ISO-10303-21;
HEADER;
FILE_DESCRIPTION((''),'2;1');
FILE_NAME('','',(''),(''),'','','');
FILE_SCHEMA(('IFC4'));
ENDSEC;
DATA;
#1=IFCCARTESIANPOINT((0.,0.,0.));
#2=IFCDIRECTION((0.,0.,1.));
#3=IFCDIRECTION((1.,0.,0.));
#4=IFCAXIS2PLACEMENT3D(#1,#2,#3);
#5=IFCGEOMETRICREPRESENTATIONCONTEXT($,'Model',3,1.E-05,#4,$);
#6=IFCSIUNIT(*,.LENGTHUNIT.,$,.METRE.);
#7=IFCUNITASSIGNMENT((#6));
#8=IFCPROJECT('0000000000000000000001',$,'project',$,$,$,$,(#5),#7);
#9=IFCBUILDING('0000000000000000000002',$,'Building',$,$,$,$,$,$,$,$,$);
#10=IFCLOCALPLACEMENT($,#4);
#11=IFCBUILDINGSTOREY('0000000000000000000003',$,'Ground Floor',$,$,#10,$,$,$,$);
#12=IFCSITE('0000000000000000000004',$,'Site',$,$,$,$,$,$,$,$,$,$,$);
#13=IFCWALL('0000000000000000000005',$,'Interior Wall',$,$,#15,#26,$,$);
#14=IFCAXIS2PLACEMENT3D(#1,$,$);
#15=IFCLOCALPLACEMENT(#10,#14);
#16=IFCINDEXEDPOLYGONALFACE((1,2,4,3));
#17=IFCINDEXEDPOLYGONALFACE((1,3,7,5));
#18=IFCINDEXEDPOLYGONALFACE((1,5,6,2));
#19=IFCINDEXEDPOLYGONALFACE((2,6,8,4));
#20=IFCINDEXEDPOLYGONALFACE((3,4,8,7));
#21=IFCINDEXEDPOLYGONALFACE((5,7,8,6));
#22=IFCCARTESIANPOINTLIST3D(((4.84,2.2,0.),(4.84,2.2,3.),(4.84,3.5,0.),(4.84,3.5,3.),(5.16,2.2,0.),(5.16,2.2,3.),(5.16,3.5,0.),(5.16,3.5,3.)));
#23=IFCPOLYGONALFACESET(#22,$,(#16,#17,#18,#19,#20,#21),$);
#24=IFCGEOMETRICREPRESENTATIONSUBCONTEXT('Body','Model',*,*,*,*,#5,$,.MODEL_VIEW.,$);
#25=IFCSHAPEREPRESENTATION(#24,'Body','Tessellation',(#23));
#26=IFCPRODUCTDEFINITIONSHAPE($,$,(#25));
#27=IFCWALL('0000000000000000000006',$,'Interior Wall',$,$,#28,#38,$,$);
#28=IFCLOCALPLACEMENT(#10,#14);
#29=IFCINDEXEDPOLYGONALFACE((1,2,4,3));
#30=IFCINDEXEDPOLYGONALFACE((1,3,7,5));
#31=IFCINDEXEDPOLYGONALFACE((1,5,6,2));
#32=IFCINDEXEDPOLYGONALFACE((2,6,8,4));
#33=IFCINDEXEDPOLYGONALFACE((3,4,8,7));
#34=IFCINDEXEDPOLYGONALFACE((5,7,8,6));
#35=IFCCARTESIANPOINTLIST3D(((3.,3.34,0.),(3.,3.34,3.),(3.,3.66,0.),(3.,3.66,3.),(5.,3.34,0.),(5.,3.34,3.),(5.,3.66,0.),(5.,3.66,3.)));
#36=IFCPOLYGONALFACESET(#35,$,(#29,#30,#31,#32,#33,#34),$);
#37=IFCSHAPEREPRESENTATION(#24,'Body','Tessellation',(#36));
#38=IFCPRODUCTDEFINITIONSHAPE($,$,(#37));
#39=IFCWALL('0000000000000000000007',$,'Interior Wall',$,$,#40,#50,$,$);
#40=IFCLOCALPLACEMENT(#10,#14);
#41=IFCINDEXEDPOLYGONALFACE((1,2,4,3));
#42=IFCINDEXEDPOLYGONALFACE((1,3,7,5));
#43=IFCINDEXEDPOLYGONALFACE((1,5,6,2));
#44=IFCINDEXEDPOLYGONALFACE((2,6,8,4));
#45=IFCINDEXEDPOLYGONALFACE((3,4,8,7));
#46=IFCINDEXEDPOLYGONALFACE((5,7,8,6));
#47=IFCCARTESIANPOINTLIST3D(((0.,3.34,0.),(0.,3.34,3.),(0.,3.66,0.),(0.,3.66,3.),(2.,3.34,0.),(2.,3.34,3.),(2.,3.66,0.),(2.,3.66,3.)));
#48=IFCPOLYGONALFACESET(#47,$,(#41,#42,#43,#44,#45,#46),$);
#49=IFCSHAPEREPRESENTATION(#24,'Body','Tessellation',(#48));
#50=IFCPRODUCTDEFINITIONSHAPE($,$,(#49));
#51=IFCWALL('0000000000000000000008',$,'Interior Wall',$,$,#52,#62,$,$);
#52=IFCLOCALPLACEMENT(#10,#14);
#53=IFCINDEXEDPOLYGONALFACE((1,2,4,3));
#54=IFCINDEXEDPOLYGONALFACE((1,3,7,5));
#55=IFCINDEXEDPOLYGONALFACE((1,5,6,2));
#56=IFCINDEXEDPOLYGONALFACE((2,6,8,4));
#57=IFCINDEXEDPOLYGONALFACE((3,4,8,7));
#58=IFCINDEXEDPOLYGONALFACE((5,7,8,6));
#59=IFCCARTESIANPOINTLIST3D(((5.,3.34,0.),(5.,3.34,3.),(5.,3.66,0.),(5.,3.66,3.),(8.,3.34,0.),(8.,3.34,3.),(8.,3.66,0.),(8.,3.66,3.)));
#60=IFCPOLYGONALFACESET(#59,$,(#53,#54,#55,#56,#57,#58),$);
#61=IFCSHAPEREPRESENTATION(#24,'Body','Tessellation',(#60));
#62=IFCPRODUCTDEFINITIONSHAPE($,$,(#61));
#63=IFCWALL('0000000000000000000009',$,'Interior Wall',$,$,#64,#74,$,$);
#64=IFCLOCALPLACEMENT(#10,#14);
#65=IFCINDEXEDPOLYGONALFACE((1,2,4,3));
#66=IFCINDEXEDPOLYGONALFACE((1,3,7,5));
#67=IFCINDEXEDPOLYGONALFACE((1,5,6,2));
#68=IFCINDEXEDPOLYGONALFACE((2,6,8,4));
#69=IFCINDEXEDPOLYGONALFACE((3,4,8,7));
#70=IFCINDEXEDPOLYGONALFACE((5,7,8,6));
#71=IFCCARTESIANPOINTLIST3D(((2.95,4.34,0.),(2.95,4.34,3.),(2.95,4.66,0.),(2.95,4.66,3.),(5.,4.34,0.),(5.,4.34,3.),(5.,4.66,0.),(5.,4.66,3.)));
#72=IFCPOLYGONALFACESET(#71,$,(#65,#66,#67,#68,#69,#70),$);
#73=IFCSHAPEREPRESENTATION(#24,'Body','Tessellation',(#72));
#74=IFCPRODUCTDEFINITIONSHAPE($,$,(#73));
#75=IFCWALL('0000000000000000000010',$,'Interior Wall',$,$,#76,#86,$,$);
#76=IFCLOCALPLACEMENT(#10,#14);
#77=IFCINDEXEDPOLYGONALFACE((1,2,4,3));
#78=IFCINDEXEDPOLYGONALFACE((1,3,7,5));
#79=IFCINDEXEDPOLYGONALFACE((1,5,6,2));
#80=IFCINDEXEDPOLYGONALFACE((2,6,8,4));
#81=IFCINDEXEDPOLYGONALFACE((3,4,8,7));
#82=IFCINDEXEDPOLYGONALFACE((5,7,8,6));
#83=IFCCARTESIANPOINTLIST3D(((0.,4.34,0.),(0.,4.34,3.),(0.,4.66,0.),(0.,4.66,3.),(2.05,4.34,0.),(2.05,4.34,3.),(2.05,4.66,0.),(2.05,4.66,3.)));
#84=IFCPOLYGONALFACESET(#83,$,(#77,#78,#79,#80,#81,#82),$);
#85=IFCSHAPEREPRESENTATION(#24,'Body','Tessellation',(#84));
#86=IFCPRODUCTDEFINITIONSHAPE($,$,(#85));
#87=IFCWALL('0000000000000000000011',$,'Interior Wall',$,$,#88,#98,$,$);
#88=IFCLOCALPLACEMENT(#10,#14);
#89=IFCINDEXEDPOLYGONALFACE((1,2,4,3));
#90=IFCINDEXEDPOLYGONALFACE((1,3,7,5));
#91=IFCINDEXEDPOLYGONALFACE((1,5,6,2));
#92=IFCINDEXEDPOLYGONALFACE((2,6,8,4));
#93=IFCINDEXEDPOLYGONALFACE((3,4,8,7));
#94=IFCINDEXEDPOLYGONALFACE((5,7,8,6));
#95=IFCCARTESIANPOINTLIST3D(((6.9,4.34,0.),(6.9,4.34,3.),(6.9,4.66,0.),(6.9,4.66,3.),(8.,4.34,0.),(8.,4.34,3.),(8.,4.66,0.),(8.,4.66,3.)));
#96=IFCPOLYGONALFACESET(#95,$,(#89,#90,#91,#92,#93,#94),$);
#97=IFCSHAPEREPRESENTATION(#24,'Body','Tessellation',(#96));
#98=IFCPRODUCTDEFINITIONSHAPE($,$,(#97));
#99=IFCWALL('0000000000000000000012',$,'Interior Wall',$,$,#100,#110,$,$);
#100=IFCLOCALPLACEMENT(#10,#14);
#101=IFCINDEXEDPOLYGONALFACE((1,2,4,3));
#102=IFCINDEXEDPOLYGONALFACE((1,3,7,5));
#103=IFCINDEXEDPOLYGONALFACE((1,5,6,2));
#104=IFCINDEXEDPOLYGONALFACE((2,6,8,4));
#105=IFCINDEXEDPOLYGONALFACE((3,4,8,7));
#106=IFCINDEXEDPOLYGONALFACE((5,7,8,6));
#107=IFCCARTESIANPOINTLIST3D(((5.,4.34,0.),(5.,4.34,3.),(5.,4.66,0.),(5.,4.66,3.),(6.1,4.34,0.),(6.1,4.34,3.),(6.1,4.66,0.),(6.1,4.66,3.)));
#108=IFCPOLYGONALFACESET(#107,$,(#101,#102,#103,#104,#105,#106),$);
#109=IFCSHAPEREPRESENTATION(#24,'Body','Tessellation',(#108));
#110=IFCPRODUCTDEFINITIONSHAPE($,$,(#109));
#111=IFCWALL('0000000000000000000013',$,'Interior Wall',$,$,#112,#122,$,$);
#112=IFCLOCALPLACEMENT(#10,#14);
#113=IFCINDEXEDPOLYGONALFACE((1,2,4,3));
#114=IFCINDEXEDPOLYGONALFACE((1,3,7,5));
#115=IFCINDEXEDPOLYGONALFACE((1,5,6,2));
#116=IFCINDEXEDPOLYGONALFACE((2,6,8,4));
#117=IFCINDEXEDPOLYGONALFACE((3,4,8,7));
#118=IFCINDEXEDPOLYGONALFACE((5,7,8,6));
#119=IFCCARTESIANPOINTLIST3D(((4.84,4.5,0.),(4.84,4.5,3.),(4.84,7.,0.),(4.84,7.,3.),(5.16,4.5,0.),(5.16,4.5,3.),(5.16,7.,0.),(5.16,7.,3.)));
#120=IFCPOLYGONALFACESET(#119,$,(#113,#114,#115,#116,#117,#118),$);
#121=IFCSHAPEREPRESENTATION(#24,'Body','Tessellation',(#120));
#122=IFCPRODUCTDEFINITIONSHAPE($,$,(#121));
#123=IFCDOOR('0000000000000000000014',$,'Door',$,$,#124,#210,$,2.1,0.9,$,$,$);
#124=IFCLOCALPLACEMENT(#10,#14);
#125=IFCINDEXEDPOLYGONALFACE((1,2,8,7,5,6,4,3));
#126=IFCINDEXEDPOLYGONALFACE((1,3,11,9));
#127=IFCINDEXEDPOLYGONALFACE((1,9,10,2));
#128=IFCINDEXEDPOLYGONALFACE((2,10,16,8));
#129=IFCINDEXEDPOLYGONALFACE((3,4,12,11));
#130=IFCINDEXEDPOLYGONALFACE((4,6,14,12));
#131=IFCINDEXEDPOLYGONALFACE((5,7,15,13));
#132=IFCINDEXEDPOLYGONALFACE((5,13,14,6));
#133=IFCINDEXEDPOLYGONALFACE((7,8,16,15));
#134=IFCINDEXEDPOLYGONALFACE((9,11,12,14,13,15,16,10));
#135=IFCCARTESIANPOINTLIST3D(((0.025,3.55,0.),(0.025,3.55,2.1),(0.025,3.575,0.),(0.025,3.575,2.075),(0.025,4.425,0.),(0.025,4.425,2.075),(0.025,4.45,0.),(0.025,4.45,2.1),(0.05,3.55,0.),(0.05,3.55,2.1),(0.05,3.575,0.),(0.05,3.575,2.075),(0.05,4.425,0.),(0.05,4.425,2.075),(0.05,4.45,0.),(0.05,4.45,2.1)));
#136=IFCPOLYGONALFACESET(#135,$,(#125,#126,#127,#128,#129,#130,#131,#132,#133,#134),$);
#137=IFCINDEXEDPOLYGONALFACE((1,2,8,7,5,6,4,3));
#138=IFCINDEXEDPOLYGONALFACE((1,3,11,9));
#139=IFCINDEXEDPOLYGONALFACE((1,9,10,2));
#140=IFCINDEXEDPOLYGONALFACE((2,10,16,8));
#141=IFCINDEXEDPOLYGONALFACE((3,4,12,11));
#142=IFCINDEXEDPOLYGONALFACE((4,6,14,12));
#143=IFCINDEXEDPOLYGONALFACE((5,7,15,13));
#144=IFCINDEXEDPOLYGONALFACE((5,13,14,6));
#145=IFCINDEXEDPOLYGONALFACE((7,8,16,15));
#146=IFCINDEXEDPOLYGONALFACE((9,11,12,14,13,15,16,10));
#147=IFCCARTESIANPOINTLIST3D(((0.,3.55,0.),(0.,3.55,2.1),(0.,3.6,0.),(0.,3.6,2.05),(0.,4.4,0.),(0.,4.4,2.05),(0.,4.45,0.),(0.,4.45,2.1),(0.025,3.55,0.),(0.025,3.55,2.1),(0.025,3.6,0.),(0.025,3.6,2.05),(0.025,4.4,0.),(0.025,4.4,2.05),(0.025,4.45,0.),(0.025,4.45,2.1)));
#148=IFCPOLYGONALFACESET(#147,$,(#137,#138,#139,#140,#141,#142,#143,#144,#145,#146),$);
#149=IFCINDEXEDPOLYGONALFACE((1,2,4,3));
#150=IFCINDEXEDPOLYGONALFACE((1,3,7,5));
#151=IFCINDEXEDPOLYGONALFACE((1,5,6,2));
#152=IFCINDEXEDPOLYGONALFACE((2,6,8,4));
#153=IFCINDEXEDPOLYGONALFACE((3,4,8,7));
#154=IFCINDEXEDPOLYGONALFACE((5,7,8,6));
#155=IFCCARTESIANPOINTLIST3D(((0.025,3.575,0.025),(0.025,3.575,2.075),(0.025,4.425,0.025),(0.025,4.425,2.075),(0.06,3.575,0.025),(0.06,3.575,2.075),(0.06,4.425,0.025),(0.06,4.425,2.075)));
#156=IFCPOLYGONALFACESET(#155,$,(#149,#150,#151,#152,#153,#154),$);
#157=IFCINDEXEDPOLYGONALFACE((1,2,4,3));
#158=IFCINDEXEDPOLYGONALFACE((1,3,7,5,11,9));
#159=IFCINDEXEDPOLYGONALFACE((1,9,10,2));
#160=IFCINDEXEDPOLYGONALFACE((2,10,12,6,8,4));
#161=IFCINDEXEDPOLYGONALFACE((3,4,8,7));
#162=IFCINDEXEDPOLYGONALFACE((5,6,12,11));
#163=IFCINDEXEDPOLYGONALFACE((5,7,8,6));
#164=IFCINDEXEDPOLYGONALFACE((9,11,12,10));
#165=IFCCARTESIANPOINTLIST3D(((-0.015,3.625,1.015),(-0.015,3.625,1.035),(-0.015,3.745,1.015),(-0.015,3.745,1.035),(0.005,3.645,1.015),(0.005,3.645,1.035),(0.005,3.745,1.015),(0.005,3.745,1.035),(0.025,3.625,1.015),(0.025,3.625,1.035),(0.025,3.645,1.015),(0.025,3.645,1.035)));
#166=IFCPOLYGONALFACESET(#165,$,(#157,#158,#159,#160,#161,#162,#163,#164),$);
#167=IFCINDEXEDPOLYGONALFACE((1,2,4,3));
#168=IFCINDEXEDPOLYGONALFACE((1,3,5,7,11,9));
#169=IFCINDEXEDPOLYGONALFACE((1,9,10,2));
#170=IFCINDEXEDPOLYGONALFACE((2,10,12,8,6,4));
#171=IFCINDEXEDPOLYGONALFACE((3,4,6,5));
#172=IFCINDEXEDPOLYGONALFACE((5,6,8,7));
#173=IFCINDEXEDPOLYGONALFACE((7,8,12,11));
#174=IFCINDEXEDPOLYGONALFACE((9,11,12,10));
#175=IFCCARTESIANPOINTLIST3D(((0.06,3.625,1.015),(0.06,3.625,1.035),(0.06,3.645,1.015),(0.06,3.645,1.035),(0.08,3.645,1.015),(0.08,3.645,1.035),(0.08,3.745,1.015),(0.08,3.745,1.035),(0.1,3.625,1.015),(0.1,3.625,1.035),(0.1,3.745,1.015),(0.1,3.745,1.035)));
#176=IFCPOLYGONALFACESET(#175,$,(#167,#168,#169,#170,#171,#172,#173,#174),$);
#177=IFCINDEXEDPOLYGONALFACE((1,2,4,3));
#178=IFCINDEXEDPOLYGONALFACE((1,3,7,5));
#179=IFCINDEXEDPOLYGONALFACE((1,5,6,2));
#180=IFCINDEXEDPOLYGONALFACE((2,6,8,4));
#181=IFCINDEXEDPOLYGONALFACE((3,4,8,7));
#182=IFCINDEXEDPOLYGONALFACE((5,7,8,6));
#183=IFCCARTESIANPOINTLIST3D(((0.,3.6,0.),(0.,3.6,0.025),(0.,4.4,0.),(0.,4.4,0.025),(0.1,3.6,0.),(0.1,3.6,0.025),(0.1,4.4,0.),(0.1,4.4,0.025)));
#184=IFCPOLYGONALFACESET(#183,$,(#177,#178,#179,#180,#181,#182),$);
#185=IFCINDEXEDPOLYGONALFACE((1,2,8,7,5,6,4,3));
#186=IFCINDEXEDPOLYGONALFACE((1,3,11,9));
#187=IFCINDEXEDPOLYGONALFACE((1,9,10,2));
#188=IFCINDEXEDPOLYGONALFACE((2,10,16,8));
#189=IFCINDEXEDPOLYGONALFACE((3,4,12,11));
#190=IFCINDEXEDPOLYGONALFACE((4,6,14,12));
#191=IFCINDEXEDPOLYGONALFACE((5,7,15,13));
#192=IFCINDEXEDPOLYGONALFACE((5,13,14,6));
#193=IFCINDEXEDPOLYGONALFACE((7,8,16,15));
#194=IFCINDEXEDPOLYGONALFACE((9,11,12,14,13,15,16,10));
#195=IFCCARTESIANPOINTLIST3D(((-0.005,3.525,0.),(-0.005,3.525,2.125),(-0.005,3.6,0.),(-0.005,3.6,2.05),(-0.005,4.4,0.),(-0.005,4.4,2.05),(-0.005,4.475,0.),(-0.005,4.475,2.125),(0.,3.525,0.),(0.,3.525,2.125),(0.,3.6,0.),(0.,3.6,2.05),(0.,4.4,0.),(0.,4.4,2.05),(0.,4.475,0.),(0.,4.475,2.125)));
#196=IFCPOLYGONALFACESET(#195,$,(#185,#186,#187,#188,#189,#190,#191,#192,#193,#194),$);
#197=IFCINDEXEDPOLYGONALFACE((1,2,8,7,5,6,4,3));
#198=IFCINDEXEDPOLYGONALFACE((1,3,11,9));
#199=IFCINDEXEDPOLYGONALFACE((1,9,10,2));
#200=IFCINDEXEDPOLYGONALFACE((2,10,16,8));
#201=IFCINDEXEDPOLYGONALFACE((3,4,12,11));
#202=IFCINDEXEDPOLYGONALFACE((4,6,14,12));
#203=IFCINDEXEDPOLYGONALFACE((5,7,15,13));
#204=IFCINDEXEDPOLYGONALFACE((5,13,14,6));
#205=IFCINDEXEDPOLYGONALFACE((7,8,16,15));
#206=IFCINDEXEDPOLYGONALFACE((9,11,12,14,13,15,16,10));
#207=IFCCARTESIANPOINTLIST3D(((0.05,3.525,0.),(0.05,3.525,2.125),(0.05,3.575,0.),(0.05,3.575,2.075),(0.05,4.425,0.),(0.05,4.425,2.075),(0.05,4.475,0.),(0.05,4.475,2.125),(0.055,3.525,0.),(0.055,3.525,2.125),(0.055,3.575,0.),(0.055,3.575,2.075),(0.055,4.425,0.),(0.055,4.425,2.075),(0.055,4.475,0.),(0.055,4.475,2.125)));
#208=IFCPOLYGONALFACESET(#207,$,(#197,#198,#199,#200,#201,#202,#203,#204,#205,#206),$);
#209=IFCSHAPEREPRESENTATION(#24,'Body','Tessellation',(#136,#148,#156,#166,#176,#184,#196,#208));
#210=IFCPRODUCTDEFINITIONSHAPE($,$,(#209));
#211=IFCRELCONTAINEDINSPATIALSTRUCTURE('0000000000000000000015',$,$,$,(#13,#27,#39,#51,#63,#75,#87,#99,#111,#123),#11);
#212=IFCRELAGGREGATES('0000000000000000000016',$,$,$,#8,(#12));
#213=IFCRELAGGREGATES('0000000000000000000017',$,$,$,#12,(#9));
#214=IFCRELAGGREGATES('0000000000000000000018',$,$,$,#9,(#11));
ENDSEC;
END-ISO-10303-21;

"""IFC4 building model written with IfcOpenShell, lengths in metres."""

from ifc_helpers import new_model, si_unit, frame, origin_with_axes, place, context, subcontext, project, spatial, line, indexed_curve, outline, extrude, element, save


model = new_model("IFC4")

# Units and contexts
model_context = context("Model", 3, precision=1e-05, world=origin_with_axes())
body_context = subcontext(model_context, "Body", "Model", "MODEL_VIEW")
ifc_project = project(units=[si_unit("LENGTHUNIT", "METRE")], contexts=[model_context])

# Site, building, storey
site = spatial("IfcSite", under=ifc_project, Name="Site")
building = spatial("IfcBuilding", under=site, Name="Building")
storey_placement = place(None, origin_with_axes())
storey = spatial("IfcBuildingStorey", under=building, at=storey_placement, Name="Ground Floor")

# Walls
wall_1_placement = place(storey_placement, frame((5.0, 2.2, 0.0), z_axis=(0.0, 0.0, 1.0), x_axis=(0.0, 1.0, 0.0)))
element("IfcWall", 1, at=wall_1_placement, inside=storey, Name="Interior Wall", context=body_context, shape_type="SweptSolid", body=[
    extrude(outline(indexed_curve([(0.0, 0.0), (0.0, 0.32), (1.3, 0.32), (1.3, 0.0), (0.0, 0.0)], self_intersect=False)), frame((0.0, -0.16, 0.0), z_axis=(0.0, 0.0, 1.0), x_axis=(1.0, 0.0, 0.0)), (0.0, 0.0, 1.0), 3.0),
])
for number, where, z_axis, x_axis, name in (
    (2, (5.0, 3.5, 0.0), (0.0, 0.0, 1.0), (-1.0, 0.0, 0.0), "Interior Wall"),
    (3, (2.0, 3.5, 0.0), (0.0, 0.0, 1.0), (-1.0, 0.0, 0.0), "Interior Wall"),
):
    element("IfcWall", number, at=place(storey_placement, frame(where, z_axis=z_axis, x_axis=x_axis)), inside=storey, Name=name, context=body_context, shape_type="SweptSolid", body=[
        extrude(outline(indexed_curve([(0.0, 0.0), (0.0, 0.32), (2.0, 0.32), (2.0, 0.0), (0.0, 0.0)], self_intersect=False)), frame((0.0, -0.16, 0.0), z_axis=(0.0, 0.0, 1.0), x_axis=(1.0, 0.0, 0.0)), (0.0, 0.0, 1.0), 3.0),
    ])
wall_2_placement = place(storey_placement, frame((8.0, 3.5, 0.0), z_axis=(0.0, 0.0, 1.0), x_axis=(-1.0, 0.0, 0.0)))
element("IfcWall", 4, at=wall_2_placement, inside=storey, Name="Interior Wall", context=body_context, shape_type="SweptSolid", body=[
    extrude(outline(indexed_curve([(0.0, 0.0), (0.0, 0.32), (3.0, 0.32), (3.0, 0.0), (0.0, 0.0)], self_intersect=False)), frame((0.0, -0.16, 0.0), z_axis=(0.0, 0.0, 1.0), x_axis=(1.0, 0.0, 0.0)), (0.0, 0.0, 1.0), 3.0),
])
for number, where, z_axis, x_axis, name in (
    (5, (5.0, 4.5, 0.0), (0.0, 0.0, 1.0), (-1.0, 0.0, 0.0), "Interior Wall"),
    (6, (2.05, 4.5, 0.0), (0.0, 0.0, 1.0), (-1.0, 0.0, 0.0), "Interior Wall"),
):
    element("IfcWall", number, at=place(storey_placement, frame(where, z_axis=z_axis, x_axis=x_axis)), inside=storey, Name=name, context=body_context, shape_type="SweptSolid", body=[
        extrude(outline(indexed_curve([(0.0, 0.0), (0.0, 0.32), (2.05, 0.32), (2.05, 0.0), (0.0, 0.0)], self_intersect=False)), frame((0.0, -0.16, 0.0), z_axis=(0.0, 0.0, 1.0), x_axis=(1.0, 0.0, 0.0)), (0.0, 0.0, 1.0), 3.0),
    ])
for number, where, z_axis, x_axis, name in (
    (7, (8.0, 4.5, 0.0), (0.0, 0.0, 1.0), (-1.0, 0.0, 0.0), "Interior Wall"),
    (8, (6.1, 4.5, 0.0), (0.0, 0.0, 1.0), (-1.0, 0.0, 0.0), "Interior Wall"),
):
    element("IfcWall", number, at=place(storey_placement, frame(where, z_axis=z_axis, x_axis=x_axis)), inside=storey, Name=name, context=body_context, shape_type="SweptSolid", body=[
        extrude(outline(indexed_curve([(0.0, 0.0), (0.0, 0.32), (1.1, 0.32), (1.1, 0.0), (0.0, 0.0)], self_intersect=False)), frame((0.0, -0.16, 0.0), z_axis=(0.0, 0.0, 1.0), x_axis=(1.0, 0.0, 0.0)), (0.0, 0.0, 1.0), 3.0),
    ])
wall_3_placement = place(storey_placement, frame((5.0, 4.5, 0.0), z_axis=(0.0, 0.0, 1.0), x_axis=(0.0, 1.0, 0.0)))
element("IfcWall", 9, at=wall_3_placement, inside=storey, Name="Interior Wall", context=body_context, shape_type="SweptSolid", body=[
    extrude(outline(indexed_curve([(0.0, 0.0), (0.0, 0.32), (2.5, 0.32), (2.5, 0.0), (0.0, 0.0)], self_intersect=False)), frame((0.0, -0.16, 0.0), z_axis=(0.0, 0.0, 1.0), x_axis=(1.0, 0.0, 0.0)), (0.0, 0.0, 1.0), 3.0),
])

# Door
door_1_placement = place(storey_placement, frame((0.0, 4.45, 0.0), z_axis=(0.0, 0.0, 1.0), x_axis=(0.0, -1.0, 0.0)))
element("IfcDoor", 10, at=door_1_placement, inside=storey, Name="Door", OverallHeight=2.1, OverallWidth=0.9, context=body_context, shape_type="SweptSolid", body=[
    extrude(outline(indexed_curve([(0.0, 0.0), (0.0, 2.1), (0.9, 2.1), (0.9, 0.0), (0.875, 0.0), (0.875, 2.075), (0.025, 2.075), (0.025, 0.0)], segments=[line(1, 2, 3, 4, 5, 6, 7, 8, 1)])), frame((0.0, 0.025, 0.0), z_axis=(0.0, -1.0, 0.0), x_axis=(1.0, 0.0, 0.0)), (0.0, 0.0, -1.0), 0.025),
    extrude(outline(indexed_curve([(0.0, 0.0), (0.0, 2.1), (0.9, 2.1), (0.9, 0.0), (0.85, 0.0), (0.85, 2.05), (0.05, 2.05), (0.05, 0.0)], segments=[line(1, 2, 3, 4, 5, 6, 7, 8, 1)])), frame((0.0, 0.0, 0.0), z_axis=(0.0, -1.0, 0.0), x_axis=(1.0, 0.0, 0.0)), (0.0, 0.0, -1.0), 0.025),
    extrude(outline(indexed_curve([(0.0, 0.0), (0.85, 0.0), (0.85, 0.035), (0.0, 0.035)], segments=[line(1, 2, 3, 4, 1)])), frame((0.025, 0.025, 0.025), z_axis=(0.0, 0.0, 1.0), x_axis=(1.0, 0.0, 0.0)), (0.0, 0.0, 1.0), 2.05),
    extrude(outline(indexed_curve([(0.0, 0.0), (0.0, -0.04), (-0.12, -0.04), (-0.12, -0.02), (-0.02, -0.02), (-0.02, 0.0)], segments=[line(1, 2, 3, 4, 5, 6, 1)])), frame((0.825, 0.025, 1.015), z_axis=(0.0, 0.0, 1.0), x_axis=(1.0, 0.0, 0.0)), (0.0, 0.0, 1.0), 0.02),
    extrude(outline(indexed_curve([(0.0, 0.0), (0.0, 0.04), (-0.12, 0.04), (-0.12, 0.02), (-0.02, 0.02), (-0.02, 0.0)], segments=[line(1, 2, 3, 4, 5, 6, 1)])), frame((0.825, 0.06, 1.015), z_axis=(0.0, 0.0, 1.0), x_axis=(1.0, 0.0, 0.0)), (0.0, 0.0, 1.0), 0.02),
    extrude(outline(indexed_curve([(0.0, 0.0), (0.8, 0.0), (0.8, 0.1), (0.0, 0.1)], segments=[line(1, 2, 3, 4, 1)])), frame((0.05, 0.0, 0.0), z_axis=(0.0, 0.0, 1.0), x_axis=(1.0, 0.0, 0.0)), (0.0, 0.0, 1.0), 0.025),
    extrude(outline(indexed_curve([(0.0, 0.0), (0.0, 2.125), (0.95, 2.125), (0.95, 0.0), (0.875, 0.0), (0.875, 2.05), (0.075, 2.05), (0.075, 0.0)], segments=[line(1, 2, 3, 4, 5, 6, 7, 8, 1)])), frame((-0.025, -0.005, 0.0), z_axis=(0.0, -1.0, 0.0), x_axis=(1.0, 0.0, 0.0)), (0.0, 0.0, -1.0), 0.005),
    extrude(outline(indexed_curve([(0.0, 0.0), (0.0, 2.125), (0.95, 2.125), (0.95, 0.0), (0.9, 0.0), (0.9, 2.075), (0.05, 2.075), (0.05, 0.0)], segments=[line(1, 2, 3, 4, 5, 6, 7, 8, 1)])), frame((-0.025, 0.05, 0.0), z_axis=(0.0, -1.0, 0.0), x_axis=(1.0, 0.0, 0.0)), (0.0, 0.0, -1.0), 0.005),
])

save(model, "model.ifc")
